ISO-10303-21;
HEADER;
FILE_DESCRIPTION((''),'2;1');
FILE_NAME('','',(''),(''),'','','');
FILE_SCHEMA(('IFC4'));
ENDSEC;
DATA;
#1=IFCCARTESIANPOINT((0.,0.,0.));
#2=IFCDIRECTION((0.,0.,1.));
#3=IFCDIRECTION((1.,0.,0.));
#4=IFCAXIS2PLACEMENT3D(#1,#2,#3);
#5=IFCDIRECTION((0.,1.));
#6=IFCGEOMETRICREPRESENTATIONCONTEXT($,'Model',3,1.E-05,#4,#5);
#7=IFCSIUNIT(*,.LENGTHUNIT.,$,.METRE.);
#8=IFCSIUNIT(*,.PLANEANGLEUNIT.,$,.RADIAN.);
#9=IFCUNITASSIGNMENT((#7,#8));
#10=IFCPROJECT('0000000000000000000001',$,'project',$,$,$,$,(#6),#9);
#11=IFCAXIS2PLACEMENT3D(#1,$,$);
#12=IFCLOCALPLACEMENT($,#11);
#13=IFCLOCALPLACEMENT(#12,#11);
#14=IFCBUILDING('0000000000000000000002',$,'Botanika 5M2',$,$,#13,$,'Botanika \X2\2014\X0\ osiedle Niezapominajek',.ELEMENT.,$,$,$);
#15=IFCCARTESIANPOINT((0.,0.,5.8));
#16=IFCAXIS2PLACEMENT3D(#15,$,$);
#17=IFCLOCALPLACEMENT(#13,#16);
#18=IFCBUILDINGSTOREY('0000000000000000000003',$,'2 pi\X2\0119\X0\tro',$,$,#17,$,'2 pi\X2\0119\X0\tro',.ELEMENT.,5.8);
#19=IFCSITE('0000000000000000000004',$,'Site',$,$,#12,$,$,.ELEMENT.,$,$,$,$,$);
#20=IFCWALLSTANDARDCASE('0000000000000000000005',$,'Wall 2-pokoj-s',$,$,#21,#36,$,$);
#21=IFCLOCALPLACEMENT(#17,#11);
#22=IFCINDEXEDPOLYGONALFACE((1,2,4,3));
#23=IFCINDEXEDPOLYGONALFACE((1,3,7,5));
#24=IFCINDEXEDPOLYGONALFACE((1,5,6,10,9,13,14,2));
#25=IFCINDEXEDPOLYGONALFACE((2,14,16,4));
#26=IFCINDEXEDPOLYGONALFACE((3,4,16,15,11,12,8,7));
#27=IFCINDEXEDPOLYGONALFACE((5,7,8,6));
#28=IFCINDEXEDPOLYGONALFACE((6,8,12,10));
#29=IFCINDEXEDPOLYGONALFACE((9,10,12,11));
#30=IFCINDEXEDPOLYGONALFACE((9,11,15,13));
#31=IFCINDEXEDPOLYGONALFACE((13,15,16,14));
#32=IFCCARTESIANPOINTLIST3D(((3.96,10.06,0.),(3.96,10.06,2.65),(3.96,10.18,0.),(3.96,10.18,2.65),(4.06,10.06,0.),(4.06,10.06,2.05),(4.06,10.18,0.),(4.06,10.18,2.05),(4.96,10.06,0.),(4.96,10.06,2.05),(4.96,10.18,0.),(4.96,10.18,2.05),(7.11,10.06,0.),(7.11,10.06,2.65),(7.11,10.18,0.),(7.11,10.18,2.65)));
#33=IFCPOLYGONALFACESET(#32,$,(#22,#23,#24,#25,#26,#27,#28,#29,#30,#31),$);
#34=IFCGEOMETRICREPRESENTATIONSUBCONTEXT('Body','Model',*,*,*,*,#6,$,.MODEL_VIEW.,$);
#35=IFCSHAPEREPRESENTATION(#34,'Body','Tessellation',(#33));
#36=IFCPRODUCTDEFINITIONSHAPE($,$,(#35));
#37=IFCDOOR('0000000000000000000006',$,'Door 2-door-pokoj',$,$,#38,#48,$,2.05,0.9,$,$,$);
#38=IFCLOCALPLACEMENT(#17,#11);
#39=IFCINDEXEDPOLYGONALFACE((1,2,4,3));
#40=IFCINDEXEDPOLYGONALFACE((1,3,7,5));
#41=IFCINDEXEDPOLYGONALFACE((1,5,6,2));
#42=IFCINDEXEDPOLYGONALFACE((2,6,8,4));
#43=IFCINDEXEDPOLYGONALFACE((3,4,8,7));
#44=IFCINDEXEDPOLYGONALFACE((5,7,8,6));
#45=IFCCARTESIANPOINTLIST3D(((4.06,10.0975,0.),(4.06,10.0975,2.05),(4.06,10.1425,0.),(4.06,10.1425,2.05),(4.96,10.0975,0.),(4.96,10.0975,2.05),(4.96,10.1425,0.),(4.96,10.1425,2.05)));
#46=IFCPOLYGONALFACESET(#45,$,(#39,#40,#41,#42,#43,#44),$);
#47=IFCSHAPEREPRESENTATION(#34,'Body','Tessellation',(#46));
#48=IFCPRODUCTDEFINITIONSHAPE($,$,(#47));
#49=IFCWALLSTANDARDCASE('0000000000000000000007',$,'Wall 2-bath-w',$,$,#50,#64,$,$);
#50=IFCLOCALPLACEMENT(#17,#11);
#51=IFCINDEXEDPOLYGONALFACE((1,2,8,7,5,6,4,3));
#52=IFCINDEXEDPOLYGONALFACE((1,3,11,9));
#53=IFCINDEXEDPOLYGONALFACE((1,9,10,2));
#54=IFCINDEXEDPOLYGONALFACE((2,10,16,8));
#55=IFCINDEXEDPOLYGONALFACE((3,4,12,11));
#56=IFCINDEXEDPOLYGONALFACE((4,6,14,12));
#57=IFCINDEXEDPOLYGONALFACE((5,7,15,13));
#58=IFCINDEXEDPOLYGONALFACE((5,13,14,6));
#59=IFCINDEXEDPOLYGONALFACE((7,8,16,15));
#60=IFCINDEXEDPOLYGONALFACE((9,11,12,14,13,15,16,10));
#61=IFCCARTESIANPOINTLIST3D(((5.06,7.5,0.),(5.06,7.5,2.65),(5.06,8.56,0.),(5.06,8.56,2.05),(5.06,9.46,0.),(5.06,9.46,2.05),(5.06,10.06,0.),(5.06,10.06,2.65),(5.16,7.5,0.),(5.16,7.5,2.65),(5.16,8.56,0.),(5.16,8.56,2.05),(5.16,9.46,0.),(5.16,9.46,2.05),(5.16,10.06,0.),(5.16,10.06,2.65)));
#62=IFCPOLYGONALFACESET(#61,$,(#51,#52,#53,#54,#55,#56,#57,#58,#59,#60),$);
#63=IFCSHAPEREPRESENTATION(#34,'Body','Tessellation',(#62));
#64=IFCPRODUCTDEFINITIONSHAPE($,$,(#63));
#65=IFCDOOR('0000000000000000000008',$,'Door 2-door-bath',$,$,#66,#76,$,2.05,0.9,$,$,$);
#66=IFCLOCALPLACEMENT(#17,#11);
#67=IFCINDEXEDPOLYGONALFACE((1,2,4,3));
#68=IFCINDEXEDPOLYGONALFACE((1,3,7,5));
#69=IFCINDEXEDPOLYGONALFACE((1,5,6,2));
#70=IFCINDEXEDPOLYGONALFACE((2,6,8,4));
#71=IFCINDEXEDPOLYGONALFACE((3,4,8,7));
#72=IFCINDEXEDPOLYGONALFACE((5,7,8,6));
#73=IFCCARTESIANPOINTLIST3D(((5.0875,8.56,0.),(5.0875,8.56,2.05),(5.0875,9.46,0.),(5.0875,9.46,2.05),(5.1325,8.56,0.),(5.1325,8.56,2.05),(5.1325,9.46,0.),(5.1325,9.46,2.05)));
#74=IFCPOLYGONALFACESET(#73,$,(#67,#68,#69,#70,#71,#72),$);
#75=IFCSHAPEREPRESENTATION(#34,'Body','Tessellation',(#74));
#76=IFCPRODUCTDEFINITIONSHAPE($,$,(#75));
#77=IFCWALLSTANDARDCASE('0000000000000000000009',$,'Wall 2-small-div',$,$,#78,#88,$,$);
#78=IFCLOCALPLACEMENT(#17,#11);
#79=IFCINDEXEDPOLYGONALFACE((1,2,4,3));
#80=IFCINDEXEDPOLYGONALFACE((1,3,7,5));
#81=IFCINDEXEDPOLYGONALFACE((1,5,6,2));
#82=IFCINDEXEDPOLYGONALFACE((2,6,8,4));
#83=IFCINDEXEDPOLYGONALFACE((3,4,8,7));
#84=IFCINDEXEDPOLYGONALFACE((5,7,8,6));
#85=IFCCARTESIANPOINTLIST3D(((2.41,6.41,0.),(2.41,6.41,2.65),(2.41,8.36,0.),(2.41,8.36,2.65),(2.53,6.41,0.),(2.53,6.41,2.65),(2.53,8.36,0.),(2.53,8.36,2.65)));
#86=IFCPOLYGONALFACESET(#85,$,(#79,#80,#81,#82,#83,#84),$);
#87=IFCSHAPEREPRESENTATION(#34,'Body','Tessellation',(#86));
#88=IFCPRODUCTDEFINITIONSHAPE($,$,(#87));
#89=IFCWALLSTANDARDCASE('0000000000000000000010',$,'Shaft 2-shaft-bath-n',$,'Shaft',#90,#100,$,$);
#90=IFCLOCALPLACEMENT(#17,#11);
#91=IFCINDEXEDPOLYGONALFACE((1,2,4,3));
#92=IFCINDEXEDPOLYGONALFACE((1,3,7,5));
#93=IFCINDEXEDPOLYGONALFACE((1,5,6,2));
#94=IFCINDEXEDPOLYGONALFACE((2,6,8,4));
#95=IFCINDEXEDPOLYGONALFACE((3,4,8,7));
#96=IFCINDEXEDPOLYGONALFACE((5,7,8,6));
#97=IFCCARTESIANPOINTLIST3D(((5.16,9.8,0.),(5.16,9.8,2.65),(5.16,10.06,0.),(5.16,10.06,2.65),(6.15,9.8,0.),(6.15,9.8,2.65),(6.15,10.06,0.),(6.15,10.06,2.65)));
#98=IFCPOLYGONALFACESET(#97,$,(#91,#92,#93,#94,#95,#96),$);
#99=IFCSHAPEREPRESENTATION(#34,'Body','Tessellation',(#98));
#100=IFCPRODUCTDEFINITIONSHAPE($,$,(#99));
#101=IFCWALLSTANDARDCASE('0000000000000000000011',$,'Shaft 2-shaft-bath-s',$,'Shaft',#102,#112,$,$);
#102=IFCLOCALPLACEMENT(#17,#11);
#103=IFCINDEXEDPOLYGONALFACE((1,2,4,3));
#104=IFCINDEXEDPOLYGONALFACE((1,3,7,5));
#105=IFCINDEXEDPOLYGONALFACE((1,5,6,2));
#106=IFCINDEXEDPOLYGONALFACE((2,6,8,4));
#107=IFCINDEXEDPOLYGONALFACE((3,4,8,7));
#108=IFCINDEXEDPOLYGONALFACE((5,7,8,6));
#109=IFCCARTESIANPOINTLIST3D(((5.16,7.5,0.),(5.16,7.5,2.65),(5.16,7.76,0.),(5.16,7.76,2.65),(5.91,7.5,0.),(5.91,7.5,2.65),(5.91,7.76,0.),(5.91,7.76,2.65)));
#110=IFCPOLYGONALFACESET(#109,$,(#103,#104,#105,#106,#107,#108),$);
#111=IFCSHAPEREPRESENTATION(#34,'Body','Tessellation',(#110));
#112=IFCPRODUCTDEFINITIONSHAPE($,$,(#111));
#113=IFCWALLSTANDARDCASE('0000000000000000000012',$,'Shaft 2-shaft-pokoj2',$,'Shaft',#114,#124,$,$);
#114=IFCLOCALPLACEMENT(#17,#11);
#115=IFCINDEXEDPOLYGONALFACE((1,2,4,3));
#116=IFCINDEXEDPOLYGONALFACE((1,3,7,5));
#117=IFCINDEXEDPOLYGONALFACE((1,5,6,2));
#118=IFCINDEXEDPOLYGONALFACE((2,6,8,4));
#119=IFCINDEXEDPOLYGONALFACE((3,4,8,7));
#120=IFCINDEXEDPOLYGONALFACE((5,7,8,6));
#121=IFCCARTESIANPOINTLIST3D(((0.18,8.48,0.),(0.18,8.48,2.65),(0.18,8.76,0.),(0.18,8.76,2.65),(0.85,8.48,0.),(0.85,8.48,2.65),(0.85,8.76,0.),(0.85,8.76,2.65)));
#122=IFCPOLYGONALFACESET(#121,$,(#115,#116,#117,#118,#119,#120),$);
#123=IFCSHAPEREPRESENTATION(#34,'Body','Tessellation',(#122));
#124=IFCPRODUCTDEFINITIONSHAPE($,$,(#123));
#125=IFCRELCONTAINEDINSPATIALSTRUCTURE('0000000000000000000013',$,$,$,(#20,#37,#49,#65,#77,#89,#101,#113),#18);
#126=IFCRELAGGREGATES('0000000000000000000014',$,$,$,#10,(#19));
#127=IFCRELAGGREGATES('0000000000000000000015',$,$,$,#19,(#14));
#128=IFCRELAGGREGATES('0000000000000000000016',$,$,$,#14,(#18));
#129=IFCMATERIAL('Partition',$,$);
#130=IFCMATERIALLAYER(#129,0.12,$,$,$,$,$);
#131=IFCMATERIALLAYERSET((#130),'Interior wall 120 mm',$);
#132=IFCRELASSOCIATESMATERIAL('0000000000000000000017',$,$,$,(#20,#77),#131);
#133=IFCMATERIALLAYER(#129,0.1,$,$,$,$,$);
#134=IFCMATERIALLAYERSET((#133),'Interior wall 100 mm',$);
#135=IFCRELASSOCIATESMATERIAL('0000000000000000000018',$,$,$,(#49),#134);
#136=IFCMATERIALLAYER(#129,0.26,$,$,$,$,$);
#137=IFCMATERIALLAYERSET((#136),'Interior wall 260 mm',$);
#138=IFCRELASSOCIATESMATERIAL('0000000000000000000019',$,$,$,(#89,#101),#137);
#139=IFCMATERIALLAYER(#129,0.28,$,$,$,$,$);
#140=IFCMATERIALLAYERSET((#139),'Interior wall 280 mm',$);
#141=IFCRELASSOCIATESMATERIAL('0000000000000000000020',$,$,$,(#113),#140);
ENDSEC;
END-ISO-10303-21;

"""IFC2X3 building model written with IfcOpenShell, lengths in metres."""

from ifc_helpers import new_model, si_unit, direction, frame, frame_2d, origin, origin_with_axes, place, context, subcontext, project, spatial, rectangle, extrude, material, layer, layer_set, layer_usage, element, fill, save


model = new_model("IFC2X3")

# Units and contexts
model_context = context("Model", 3, precision=1e-05, world=origin_with_axes(), true_north=direction((0.0, 1.0)))
body_context = subcontext(model_context, "Body", "Model", "MODEL_VIEW")
ifc_project = project(units=[si_unit("LENGTHUNIT", "METRE"), si_unit("PLANEANGLEUNIT", "RADIAN")], contexts=[model_context])

# Site, building, storey
site_placement = place(None, origin())
site = spatial("IfcSite", under=ifc_project, at=site_placement, Name="Site", CompositionType="ELEMENT")
building_placement = place(site_placement, origin())
building = spatial("IfcBuilding", under=site, at=building_placement, Name="Botanika 5M2", LongName="Botanika — osiedle Niezapominajek", CompositionType="ELEMENT")
storey_placement = place(building_placement, frame((0.0, 0.0, 5.8)))
storey = spatial("IfcBuildingStorey", under=building, at=storey_placement, Name="2 piętro", LongName="2 piętro", CompositionType="ELEMENT", Elevation=5.8)

# Shared definitions
ifc_material_1 = material(Name="Partition")
ifc_layer_1 = layer(ifc_material_1, 0.1)
ifc_layer_set_1 = layer_set([ifc_layer_1], Name="Interior wall 100 mm")
ifc_layer_usage_1 = layer_usage(ifc_layer_set_1, "AXIS2", "POSITIVE", -0.05)

# Shared definitions
ifc_layer_2 = layer(ifc_material_1, 0.12)
ifc_layer_set_2 = layer_set([ifc_layer_2], Name="Interior wall 120 mm")
ifc_layer_usage_2 = layer_usage(ifc_layer_set_2, "AXIS2", "POSITIVE", -0.06)

# Walls, openings, doors
wall_1_placement = place(storey_placement, frame((3.96, 10.12, 0.0)))
wall_1 = element("IfcWallStandardCase", 1, at=wall_1_placement, inside=storey, material=ifc_layer_usage_2, Name="Wall 2-pokoj-s", context=body_context, shape_type="SweptSolid", body=[
    extrude(rectangle(XDim=3.15, YDim=0.12, at=frame_2d((1.575, 0.0))), origin_with_axes(), (0.0, 0.0, 1.0), 2.65),
])
opening_1_placement = place(wall_1_placement, frame((0.1, 0.11, 0.0), z_axis=(0.0, -1.0, 0.0), x_axis=(1.0, 0.0, 0.0)))
opening_1 = element("IfcOpeningElement", 2, at=opening_1_placement, cuts=wall_1, context=body_context, shape_type="SweptSolid", body=[
    extrude(rectangle(XDim=0.9, YDim=2.05, at=frame_2d((0.45, 1.025))), origin_with_axes(), (0.0, 0.0, 1.0), 0.22),
])
door_1_placement = place(wall_1_placement, frame((0.1, 0.0, 0.0)))
door_1 = element("IfcDoor", 3, at=door_1_placement, inside=storey, Name="Door 2-door-pokoj", OverallHeight=2.05, OverallWidth=0.9, context=body_context, shape_type="SweptSolid", body=[
    extrude(rectangle(XDim=0.9, YDim=0.045, at=frame_2d((0.45, 0.0))), origin_with_axes(), (0.0, 0.0, 1.0), 2.05),
])
fill(opening_1, door_1)
wall_2_placement = place(storey_placement, frame((5.11, 10.06, 0.0), z_axis=(0.0, 0.0, 1.0), x_axis=(0.0, -1.0, 0.0)))
wall_2 = element("IfcWallStandardCase", 4, at=wall_2_placement, inside=storey, material=ifc_layer_usage_1, Name="Wall 2-bath-w", context=body_context, shape_type="SweptSolid", body=[
    extrude(rectangle(XDim=2.56, YDim=0.1, at=frame_2d((1.28, 0.0))), origin_with_axes(), (0.0, 0.0, 1.0), 2.65),
])
opening_2_placement = place(wall_2_placement, frame((0.6, 0.1, 0.0), z_axis=(0.0, -1.0, 0.0), x_axis=(1.0, 0.0, 0.0)))
opening_2 = element("IfcOpeningElement", 5, at=opening_2_placement, cuts=wall_2, context=body_context, shape_type="SweptSolid", body=[
    extrude(rectangle(XDim=0.9, YDim=2.05, at=frame_2d((0.45, 1.025))), origin_with_axes(), (0.0, 0.0, 1.0), 0.2),
])
door_2_placement = place(wall_2_placement, frame((0.6, 0.0, 0.0)))
door_2 = element("IfcDoor", 6, at=door_2_placement, inside=storey, Name="Door 2-door-bath", OverallHeight=2.05, OverallWidth=0.9, context=body_context, shape_type="SweptSolid", body=[
    extrude(rectangle(XDim=0.9, YDim=0.045, at=frame_2d((0.45, 0.0))), origin_with_axes(), (0.0, 0.0, 1.0), 2.05),
])
fill(opening_2, door_2)

# Walls
wall_3_placement = place(storey_placement, frame((2.47, 8.36, 0.0), z_axis=(0.0, 0.0, 1.0), x_axis=(0.0, -1.0, 0.0)))
element("IfcWallStandardCase", 7, at=wall_3_placement, inside=storey, material=ifc_layer_usage_2, Name="Wall 2-small-div", context=body_context, shape_type="SweptSolid", body=[
    extrude(rectangle(XDim=1.95, YDim=0.12, at=frame_2d((0.975, 0.0))), origin_with_axes(), (0.0, 0.0, 1.0), 2.65),
])
ifc_layer_3 = layer(ifc_material_1, 0.26)
ifc_layer_set_3 = layer_set([ifc_layer_3], Name="Interior wall 260 mm")
ifc_layer_usage_3 = layer_usage(ifc_layer_set_3, "AXIS2", "POSITIVE", -0.13)
wall_4_placement = place(storey_placement, frame((5.16, 9.93, 0.0)))
element("IfcWallStandardCase", 8, at=wall_4_placement, inside=storey, material=ifc_layer_usage_3, Name="Shaft 2-shaft-bath-n", ObjectType="Shaft", context=body_context, shape_type="SweptSolid", body=[
    extrude(rectangle(XDim=0.99, YDim=0.26, at=frame_2d((0.495, 0.0))), origin_with_axes(), (0.0, 0.0, 1.0), 2.65),
])
wall_5_placement = place(storey_placement, frame((5.16, 7.63, 0.0)))
element("IfcWallStandardCase", 9, at=wall_5_placement, inside=storey, material=ifc_layer_usage_3, Name="Shaft 2-shaft-bath-s", ObjectType="Shaft", context=body_context, shape_type="SweptSolid", body=[
    extrude(rectangle(XDim=0.75, YDim=0.26, at=frame_2d((0.375, 0.0))), origin_with_axes(), (0.0, 0.0, 1.0), 2.65),
])
ifc_layer_4 = layer(ifc_material_1, 0.28)
ifc_layer_set_4 = layer_set([ifc_layer_4], Name="Interior wall 280 mm")
ifc_layer_usage_4 = layer_usage(ifc_layer_set_4, "AXIS2", "POSITIVE", -0.14)
wall_6_placement = place(storey_placement, frame((0.18, 8.62, 0.0)))
element("IfcWallStandardCase", 10, at=wall_6_placement, inside=storey, material=ifc_layer_usage_4, Name="Shaft 2-shaft-pokoj2", ObjectType="Shaft", context=body_context, shape_type="SweptSolid", body=[
    extrude(rectangle(XDim=0.67, YDim=0.28, at=frame_2d((0.335, 0.0))), origin_with_axes(), (0.0, 0.0, 1.0), 2.65),
])

save(model, "model.ifc")
